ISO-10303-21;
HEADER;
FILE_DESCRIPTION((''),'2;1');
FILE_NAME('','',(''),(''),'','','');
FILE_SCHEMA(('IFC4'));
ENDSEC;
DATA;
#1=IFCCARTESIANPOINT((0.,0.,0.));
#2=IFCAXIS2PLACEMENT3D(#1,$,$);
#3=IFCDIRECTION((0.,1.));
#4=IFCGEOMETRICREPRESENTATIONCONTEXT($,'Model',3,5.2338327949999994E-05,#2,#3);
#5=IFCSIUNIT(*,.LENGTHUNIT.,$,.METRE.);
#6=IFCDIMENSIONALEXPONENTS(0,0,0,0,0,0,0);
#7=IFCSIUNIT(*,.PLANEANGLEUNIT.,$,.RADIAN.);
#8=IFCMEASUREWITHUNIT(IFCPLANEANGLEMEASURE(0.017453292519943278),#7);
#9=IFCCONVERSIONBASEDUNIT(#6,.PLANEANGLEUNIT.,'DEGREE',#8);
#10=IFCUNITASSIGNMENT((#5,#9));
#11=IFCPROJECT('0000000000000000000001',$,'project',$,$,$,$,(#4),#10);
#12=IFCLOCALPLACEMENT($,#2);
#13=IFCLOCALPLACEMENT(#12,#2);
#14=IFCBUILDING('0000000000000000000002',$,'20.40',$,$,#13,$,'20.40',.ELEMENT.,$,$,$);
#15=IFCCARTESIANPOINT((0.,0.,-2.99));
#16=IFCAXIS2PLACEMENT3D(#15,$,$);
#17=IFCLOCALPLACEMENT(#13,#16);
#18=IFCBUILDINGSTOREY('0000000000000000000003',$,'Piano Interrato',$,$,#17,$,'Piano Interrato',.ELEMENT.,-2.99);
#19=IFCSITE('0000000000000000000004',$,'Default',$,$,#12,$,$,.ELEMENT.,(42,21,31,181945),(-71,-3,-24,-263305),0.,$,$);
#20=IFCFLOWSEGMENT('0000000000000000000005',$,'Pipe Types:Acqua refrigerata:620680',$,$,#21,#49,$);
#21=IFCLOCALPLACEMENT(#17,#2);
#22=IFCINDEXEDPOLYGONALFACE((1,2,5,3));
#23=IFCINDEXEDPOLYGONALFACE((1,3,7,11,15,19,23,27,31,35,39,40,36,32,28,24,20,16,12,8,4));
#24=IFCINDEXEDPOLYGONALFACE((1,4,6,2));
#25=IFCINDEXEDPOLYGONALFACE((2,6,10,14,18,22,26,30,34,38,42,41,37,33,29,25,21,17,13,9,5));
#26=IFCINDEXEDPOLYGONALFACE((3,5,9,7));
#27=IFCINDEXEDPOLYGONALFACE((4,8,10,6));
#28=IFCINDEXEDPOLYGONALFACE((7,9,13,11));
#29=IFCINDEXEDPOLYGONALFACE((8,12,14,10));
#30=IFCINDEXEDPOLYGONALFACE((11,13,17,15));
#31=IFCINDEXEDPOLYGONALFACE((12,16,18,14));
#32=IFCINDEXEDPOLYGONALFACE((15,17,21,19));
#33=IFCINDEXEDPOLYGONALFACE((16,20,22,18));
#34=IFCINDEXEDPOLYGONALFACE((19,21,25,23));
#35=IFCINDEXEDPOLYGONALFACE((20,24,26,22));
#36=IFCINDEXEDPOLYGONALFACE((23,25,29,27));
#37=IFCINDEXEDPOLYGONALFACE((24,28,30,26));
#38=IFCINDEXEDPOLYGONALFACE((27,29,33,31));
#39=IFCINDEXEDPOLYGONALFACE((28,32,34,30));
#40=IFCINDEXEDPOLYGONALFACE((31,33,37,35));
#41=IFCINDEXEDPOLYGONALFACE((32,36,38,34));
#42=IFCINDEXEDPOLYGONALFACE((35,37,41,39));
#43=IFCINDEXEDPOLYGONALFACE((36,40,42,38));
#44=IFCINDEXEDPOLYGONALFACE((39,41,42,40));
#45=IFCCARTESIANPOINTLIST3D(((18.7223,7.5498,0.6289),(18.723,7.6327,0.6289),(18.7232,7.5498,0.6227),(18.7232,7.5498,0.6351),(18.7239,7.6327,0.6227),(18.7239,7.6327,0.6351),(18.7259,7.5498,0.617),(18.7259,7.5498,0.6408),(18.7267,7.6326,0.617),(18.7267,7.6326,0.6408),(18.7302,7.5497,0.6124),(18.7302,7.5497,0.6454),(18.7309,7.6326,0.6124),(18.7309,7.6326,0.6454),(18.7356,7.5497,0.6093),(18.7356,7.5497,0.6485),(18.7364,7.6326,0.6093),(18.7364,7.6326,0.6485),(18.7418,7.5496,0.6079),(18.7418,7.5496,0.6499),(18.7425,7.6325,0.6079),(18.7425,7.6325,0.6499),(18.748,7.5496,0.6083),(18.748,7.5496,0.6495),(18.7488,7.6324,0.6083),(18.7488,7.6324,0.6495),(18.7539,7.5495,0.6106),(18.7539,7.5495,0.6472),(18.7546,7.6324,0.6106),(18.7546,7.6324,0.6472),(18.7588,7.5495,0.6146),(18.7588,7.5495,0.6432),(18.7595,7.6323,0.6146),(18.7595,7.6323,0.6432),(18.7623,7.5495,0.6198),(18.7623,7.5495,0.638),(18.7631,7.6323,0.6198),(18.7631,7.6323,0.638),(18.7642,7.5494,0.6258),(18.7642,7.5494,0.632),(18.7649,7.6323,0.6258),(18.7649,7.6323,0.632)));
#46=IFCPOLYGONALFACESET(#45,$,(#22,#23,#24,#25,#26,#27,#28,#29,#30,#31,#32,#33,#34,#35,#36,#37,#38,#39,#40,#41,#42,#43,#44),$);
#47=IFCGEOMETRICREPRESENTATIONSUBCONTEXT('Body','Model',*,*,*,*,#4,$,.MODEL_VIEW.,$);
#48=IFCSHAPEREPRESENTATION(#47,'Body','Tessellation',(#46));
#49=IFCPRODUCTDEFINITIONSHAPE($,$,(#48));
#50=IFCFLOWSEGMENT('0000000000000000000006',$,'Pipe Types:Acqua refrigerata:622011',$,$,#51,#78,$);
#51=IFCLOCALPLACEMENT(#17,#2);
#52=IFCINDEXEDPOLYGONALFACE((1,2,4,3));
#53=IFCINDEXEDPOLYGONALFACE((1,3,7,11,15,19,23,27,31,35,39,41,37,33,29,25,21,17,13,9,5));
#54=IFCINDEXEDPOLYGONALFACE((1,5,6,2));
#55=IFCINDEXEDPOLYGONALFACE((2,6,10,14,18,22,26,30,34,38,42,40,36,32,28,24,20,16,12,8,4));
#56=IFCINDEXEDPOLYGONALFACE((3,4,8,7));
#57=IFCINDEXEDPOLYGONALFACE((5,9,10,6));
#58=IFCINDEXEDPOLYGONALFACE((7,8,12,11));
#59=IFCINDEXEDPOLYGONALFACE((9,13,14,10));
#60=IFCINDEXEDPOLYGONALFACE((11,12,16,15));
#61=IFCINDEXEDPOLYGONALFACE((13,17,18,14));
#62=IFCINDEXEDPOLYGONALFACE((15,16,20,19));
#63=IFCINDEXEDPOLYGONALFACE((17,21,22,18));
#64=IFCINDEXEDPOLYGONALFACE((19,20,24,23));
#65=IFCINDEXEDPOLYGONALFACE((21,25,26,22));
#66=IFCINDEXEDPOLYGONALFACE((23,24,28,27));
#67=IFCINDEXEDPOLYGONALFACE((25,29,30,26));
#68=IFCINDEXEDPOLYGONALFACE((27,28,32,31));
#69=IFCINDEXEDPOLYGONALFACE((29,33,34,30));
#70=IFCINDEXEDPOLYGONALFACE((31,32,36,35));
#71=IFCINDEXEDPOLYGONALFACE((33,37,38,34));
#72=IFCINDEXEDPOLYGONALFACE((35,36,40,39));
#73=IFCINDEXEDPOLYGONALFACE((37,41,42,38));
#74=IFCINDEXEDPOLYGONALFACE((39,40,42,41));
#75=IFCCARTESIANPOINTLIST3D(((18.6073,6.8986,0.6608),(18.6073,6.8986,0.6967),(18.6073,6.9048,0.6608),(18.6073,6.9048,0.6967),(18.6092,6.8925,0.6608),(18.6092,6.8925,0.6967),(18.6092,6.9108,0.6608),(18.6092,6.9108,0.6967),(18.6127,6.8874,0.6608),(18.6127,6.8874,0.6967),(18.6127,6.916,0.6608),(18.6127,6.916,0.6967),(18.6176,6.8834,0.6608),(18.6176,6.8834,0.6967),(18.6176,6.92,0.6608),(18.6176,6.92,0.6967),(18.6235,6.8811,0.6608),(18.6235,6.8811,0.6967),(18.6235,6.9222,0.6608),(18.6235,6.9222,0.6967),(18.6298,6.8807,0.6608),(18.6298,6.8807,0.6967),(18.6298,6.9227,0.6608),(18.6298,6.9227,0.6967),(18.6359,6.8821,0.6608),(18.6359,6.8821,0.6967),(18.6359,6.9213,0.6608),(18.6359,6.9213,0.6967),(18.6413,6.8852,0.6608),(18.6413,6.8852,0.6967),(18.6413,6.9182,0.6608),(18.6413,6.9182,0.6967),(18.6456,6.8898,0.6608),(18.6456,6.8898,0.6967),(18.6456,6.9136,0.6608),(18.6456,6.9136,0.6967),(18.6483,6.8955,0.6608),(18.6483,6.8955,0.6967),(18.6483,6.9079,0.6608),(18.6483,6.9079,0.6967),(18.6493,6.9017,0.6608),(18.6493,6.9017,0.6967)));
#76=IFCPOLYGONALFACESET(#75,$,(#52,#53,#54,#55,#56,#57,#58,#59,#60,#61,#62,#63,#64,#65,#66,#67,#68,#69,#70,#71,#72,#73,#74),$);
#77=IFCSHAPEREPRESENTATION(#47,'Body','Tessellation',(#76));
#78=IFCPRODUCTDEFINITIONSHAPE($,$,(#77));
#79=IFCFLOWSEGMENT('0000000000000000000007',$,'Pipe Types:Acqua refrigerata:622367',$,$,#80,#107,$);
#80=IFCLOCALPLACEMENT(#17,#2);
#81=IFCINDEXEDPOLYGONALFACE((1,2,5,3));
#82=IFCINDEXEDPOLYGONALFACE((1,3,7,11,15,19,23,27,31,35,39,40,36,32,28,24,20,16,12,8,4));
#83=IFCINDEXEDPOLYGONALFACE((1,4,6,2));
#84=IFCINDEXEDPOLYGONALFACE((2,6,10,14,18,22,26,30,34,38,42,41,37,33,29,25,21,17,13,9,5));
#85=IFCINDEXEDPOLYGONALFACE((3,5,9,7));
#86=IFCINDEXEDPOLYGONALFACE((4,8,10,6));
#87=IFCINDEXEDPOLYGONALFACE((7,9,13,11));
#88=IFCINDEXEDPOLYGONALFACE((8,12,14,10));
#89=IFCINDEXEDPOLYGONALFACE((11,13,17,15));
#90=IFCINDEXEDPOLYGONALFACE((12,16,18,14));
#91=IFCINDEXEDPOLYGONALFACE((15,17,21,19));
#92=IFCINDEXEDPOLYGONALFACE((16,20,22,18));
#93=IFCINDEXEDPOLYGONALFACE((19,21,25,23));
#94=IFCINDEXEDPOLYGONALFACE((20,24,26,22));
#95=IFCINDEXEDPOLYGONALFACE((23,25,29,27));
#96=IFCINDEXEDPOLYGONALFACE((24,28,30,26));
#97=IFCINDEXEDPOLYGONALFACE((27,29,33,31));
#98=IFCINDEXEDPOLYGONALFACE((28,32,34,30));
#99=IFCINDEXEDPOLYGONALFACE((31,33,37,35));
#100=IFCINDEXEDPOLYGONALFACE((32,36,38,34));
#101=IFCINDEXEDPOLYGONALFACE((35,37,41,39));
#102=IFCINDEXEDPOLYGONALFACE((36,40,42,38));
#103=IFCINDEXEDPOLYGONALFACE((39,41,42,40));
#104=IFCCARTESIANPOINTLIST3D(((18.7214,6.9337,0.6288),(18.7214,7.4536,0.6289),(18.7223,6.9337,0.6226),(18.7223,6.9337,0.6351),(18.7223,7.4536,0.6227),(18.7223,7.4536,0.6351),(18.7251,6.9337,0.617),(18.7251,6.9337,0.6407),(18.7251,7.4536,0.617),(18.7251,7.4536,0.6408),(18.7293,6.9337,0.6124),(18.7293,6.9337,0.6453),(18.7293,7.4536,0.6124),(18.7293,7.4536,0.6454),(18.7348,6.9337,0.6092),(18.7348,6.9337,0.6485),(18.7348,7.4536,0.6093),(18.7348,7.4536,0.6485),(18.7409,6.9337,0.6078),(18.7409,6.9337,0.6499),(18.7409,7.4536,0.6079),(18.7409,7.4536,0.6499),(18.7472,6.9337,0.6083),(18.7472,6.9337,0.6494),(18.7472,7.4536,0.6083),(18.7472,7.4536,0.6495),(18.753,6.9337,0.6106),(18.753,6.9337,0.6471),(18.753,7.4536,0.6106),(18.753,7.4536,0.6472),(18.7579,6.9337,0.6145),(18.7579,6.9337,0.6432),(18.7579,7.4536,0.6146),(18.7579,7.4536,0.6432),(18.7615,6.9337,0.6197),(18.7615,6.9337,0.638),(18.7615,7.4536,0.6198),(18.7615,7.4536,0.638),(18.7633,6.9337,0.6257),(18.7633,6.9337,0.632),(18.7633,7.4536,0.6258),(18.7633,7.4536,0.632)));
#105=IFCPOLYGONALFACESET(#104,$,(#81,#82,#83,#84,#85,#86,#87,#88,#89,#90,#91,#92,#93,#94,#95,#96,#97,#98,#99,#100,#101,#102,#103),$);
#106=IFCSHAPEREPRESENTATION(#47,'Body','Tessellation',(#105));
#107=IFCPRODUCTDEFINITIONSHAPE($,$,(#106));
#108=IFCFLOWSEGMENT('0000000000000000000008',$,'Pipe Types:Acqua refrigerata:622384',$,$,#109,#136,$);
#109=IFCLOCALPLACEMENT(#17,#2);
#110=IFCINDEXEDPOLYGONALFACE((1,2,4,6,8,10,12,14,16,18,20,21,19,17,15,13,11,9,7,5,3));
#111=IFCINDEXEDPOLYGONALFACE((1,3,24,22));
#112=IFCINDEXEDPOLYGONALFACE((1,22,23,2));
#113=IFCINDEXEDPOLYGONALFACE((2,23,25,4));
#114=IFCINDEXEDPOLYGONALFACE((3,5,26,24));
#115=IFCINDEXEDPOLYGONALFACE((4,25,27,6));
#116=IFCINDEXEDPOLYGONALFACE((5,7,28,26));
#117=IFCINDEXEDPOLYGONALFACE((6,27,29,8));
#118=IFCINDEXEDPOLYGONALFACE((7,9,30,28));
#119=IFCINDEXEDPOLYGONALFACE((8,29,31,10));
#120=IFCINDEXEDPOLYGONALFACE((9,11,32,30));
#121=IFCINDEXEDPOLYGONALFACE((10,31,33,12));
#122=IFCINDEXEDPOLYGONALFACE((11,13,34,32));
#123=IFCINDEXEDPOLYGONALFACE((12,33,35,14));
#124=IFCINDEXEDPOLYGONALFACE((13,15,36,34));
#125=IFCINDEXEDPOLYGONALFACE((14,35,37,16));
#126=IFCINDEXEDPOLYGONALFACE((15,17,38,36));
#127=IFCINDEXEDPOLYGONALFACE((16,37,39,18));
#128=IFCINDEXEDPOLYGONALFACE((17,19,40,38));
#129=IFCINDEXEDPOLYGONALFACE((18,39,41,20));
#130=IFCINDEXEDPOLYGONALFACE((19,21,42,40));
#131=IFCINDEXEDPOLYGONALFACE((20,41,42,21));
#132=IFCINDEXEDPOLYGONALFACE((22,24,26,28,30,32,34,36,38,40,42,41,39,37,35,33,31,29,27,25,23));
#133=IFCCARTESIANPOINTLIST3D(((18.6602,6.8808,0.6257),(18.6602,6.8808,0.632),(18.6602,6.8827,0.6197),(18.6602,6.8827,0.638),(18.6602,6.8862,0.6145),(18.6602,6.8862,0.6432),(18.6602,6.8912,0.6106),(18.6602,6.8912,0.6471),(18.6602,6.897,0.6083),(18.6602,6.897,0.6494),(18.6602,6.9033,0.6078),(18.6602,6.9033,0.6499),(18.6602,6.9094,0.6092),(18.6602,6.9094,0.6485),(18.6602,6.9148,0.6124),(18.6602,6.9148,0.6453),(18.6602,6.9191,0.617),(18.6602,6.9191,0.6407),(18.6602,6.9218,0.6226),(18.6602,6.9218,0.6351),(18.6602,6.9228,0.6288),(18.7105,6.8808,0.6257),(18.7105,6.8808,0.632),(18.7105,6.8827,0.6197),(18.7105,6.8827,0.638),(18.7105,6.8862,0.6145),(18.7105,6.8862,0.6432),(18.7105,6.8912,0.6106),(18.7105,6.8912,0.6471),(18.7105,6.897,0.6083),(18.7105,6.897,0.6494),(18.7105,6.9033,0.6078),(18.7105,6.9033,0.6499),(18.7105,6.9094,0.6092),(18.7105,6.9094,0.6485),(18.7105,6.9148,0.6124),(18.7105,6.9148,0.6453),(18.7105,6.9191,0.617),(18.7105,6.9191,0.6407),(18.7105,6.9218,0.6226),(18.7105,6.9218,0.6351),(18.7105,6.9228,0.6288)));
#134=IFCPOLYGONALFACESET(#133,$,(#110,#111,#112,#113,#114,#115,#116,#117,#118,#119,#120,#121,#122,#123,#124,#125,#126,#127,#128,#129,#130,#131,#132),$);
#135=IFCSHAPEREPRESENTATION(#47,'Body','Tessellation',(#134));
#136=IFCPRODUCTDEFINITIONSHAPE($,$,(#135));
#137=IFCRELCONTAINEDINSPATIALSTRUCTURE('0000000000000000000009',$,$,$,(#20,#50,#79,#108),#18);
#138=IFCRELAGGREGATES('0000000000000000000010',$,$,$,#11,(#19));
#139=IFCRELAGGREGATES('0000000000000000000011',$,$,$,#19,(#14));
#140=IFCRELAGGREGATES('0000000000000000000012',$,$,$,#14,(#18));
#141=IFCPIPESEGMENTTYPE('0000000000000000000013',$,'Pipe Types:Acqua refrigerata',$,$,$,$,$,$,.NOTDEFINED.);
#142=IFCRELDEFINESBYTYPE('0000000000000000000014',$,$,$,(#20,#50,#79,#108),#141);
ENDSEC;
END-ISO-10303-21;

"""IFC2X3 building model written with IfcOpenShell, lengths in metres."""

from ifc_helpers import new_model, entity, si_unit, converted_unit, direction, frame, frame_2d, origin, origin_2d_with_axis, place, context, subcontext, project, spatial, circle, extrude, type_object, element, save


model = new_model("IFC2X3")

# Units and contexts
model_context = context("Model", 3, precision=5.2338327949999994e-05, world=origin(), true_north=direction((0.0, 1.0)))
body_context = subcontext(model_context, "Body", "Model", "MODEL_VIEW")
ifc_project = project(units=[si_unit("LENGTHUNIT", "METRE"), converted_unit("PLANEANGLEUNIT", "DEGREE", entity("IfcPlaneAngleMeasure", 0.017453292519943278), si_unit("PLANEANGLEUNIT", "RADIAN"), dimensions=[0, 0, 0, 0, 0, 0, 0])], contexts=[model_context])

# Site, building, storey
site_placement = place(None, origin())
site = spatial("IfcSite", under=ifc_project, at=site_placement, Name="Default", CompositionType="ELEMENT", RefLatitude=(42, 21, 31, 181945), RefLongitude=(-71, -3, -24, -263305), RefElevation=0.0)
building_placement = place(site_placement, origin())
building = spatial("IfcBuilding", under=site, at=building_placement, Name="20.40", LongName="20.40", CompositionType="ELEMENT")
storey_placement = place(building_placement, frame((0.0, 0.0, -2.99)))
storey = spatial("IfcBuildingStorey", under=building, at=storey_placement, Name="Piano Interrato", LongName="Piano Interrato", CompositionType="ELEMENT", Elevation=-2.99)

# Flow segments
pipe_segment_type_1 = type_object("IfcPipeSegmentType", Name="Pipe Types:Acqua refrigerata", PredefinedType="NOTDEFINED")
flow_segment_1_placement = place(storey_placement, origin())
element("IfcFlowSegment", 1, at=flow_segment_1_placement, inside=storey, type_object=pipe_segment_type_1, Name="Pipe Types:Acqua refrigerata:620680", context=body_context, shape_type="SweptSolid", body=[
    extrude(circle(Radius=0.0211, at=origin_2d_with_axis()), frame((18.7433, 7.5496, 0.6289), z_axis=(0.009014, 0.999959, 0.0), x_axis=(-0.999959, 0.009014, 0.0)), (0.0, 0.0, 1.0), 0.0829),
])
flow_segment_2_placement = place(storey_placement, origin())
element("IfcFlowSegment", 2, at=flow_segment_2_placement, inside=storey, type_object=pipe_segment_type_1, Name="Pipe Types:Acqua refrigerata:622011", context=body_context, shape_type="SweptSolid", body=[
    extrude(circle(Radius=0.0211, at=origin_2d_with_axis()), frame((18.6282, 6.9017, 0.6608)), (0.0, 0.0, 1.0), 0.0358),
])
flow_segment_3_placement = place(storey_placement, origin())
element("IfcFlowSegment", 3, at=flow_segment_3_placement, inside=storey, type_object=pipe_segment_type_1, Name="Pipe Types:Acqua refrigerata:622367", context=body_context, shape_type="SweptSolid", body=[
    extrude(circle(Radius=0.0211, at=origin_2d_with_axis()), frame((18.7425, 6.9337, 0.6288), z_axis=(0.0, 1.0, 0.000103), x_axis=(-1.0, 0.0, 0.0)), (0.0, 0.0, 1.0), 0.5199),
])
flow_segment_4_placement = place(storey_placement, origin())
element("IfcFlowSegment", 4, at=flow_segment_4_placement, inside=storey, type_object=pipe_segment_type_1, Name="Pipe Types:Acqua refrigerata:622384", context=body_context, shape_type="SweptSolid", body=[
    extrude(circle(Radius=0.0211, at=frame_2d((0.0, 0.0), x_axis=(1.0, 0.0))), frame((18.6602, 6.9017, 0.6288), z_axis=(1.0, 0.0, 0.0), x_axis=(0.0, 1.0, 0.0)), (0.0, 0.0, 1.0), 0.0503),
])

save(model, "model.ifc")
